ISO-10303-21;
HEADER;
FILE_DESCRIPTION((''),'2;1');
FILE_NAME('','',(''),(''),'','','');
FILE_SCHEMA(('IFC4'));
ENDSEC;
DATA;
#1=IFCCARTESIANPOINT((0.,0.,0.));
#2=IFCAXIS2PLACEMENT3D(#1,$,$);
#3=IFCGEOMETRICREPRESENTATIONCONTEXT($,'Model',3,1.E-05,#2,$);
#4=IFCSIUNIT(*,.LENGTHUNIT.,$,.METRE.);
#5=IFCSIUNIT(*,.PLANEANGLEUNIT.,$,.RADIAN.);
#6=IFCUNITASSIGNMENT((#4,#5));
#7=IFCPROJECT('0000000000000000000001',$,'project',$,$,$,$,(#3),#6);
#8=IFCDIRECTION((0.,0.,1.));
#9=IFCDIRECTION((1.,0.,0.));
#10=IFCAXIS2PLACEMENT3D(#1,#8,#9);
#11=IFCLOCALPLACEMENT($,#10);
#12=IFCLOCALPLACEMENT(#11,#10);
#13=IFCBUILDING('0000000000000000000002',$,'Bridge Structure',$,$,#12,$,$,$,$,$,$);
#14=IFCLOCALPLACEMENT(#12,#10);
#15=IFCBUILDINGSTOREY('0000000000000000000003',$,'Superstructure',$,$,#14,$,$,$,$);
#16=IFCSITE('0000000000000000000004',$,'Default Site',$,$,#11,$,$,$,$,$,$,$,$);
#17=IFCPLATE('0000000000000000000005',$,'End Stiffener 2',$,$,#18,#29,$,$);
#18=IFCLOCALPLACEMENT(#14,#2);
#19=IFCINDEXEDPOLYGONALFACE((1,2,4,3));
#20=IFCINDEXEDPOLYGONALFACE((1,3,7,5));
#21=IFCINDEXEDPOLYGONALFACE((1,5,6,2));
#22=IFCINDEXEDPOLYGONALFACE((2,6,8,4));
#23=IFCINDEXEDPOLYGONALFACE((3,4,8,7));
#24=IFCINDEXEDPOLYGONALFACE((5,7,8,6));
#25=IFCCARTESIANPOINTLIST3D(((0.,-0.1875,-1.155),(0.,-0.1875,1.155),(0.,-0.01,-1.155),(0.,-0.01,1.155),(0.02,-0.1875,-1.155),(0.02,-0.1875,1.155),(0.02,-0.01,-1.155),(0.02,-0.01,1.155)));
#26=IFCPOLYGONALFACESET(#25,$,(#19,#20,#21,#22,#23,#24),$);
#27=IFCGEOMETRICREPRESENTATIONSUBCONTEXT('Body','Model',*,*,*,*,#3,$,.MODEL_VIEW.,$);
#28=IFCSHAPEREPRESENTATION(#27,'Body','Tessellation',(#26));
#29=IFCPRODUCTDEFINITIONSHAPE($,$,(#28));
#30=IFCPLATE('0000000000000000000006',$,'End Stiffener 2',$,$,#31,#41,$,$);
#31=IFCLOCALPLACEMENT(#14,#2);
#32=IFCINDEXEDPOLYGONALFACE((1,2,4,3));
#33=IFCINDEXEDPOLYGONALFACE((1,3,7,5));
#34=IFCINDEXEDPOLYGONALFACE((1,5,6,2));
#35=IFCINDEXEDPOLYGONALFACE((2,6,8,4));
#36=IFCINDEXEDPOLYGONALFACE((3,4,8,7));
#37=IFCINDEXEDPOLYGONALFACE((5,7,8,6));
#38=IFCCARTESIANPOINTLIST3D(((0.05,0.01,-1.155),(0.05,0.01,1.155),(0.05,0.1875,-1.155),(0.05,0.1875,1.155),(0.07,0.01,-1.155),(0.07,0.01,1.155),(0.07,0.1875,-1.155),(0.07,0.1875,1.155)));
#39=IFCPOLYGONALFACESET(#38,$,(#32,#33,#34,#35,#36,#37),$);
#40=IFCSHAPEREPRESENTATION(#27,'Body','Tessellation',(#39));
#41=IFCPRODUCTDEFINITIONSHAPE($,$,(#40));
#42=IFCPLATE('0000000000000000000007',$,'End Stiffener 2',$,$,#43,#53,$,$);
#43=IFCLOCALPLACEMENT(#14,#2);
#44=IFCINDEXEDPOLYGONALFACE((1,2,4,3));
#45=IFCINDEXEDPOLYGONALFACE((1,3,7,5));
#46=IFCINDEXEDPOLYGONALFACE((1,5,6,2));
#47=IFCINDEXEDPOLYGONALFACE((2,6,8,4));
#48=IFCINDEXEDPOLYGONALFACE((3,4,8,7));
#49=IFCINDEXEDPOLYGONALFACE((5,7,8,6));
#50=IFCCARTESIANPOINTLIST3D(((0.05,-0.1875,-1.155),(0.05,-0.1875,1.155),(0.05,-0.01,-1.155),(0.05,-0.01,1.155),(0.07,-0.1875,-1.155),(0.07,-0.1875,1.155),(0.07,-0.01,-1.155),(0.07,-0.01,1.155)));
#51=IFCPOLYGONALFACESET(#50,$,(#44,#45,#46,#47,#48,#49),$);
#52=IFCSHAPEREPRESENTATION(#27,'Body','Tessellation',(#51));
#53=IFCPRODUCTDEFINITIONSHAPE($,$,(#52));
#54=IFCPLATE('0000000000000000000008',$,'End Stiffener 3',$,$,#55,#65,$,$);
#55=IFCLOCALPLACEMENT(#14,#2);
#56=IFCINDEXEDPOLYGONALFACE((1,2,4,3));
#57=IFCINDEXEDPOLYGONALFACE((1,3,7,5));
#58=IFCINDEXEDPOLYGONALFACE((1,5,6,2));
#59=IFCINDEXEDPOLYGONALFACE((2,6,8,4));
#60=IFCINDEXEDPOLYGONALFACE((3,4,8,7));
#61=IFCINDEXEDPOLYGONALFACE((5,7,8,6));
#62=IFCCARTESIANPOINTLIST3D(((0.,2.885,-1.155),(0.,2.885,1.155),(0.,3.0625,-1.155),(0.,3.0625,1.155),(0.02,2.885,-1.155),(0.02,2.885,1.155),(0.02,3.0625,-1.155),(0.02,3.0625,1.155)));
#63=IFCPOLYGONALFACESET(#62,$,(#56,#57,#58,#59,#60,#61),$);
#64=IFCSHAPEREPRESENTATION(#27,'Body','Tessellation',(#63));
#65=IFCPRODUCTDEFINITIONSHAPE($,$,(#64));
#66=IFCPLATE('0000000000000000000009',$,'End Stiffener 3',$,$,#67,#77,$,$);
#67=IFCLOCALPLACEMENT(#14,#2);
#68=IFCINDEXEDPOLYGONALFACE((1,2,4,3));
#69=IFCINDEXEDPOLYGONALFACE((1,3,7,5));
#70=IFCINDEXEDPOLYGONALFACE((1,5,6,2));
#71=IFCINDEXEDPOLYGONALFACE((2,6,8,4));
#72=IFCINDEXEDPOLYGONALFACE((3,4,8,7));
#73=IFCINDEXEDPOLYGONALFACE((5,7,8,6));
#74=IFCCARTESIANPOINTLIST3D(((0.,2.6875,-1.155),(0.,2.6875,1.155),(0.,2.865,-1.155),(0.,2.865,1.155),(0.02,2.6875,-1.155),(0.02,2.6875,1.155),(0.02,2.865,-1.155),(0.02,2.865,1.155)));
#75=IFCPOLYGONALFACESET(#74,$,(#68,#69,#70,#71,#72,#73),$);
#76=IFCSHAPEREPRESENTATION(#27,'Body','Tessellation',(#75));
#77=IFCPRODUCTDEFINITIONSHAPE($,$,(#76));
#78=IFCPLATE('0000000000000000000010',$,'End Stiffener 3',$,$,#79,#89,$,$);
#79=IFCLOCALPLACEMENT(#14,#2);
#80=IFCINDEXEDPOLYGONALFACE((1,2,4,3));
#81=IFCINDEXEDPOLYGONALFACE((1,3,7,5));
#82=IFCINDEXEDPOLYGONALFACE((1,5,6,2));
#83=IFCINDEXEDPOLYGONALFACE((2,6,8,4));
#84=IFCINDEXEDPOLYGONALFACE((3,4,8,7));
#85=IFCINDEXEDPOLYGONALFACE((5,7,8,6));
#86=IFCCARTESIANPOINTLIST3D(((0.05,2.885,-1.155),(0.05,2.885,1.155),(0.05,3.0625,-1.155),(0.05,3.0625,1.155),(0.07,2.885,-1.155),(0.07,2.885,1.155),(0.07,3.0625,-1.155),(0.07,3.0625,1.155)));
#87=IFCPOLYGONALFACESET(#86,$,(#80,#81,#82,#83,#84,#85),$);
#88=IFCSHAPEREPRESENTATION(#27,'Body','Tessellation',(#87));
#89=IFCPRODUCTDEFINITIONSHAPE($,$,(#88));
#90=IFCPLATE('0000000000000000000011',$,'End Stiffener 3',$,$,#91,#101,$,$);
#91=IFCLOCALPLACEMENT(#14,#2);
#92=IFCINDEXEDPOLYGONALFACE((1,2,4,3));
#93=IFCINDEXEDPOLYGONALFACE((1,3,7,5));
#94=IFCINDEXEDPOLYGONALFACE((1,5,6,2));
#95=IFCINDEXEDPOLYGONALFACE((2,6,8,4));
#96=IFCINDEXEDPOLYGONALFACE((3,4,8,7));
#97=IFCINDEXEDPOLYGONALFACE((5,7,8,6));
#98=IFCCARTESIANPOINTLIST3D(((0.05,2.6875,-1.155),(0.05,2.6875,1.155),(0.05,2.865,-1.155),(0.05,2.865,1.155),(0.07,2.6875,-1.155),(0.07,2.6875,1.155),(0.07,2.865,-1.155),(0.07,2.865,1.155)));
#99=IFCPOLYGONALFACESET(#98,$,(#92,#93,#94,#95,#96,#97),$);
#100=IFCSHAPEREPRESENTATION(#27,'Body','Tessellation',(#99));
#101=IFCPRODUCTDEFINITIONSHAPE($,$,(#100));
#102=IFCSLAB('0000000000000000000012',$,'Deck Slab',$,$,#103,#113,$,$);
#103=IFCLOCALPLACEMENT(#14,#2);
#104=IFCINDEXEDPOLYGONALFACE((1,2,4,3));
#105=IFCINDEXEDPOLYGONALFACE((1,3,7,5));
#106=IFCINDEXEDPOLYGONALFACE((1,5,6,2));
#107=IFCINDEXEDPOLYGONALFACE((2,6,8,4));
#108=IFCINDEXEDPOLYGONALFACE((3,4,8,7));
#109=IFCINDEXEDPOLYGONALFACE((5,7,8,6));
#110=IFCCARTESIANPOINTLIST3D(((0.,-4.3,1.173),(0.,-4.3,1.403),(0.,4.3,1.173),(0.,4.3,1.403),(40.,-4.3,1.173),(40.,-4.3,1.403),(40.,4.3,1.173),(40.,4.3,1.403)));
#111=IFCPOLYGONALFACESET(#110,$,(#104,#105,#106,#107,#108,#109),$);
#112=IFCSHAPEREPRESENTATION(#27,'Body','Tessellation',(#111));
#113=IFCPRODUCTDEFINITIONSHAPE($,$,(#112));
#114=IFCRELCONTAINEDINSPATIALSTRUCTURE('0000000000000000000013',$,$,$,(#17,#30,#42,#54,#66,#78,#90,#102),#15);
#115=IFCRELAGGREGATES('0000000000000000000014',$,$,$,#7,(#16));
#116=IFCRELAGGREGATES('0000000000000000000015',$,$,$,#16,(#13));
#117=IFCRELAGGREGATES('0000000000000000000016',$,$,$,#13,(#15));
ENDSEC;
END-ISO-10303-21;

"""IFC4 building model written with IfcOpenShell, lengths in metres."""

from ifc_helpers import new_model, si_unit, frame, origin, origin_with_axes, origin_2d_with_axis, place, context, subcontext, project, spatial, polyline, rectangle, outline, extrude, element, save


model = new_model("IFC4")

# Units and contexts
model_context = context("Model", 3, precision=1e-05, world=origin())
body_context = subcontext(model_context, "Body", "Model", "MODEL_VIEW")
ifc_project = project(units=[si_unit("LENGTHUNIT", "METRE"), si_unit("PLANEANGLEUNIT", "RADIAN")], contexts=[model_context])

# Site, building, storey
site_placement = place(None, origin_with_axes())
site = spatial("IfcSite", under=ifc_project, at=site_placement, Name="Default Site")
building_placement = place(site_placement, origin_with_axes())
building = spatial("IfcBuilding", under=site, at=building_placement, Name="Bridge Structure")
storey_placement = place(building_placement, origin_with_axes())
storey = spatial("IfcBuildingStorey", under=building, at=storey_placement, Name="Superstructure")

# Plates
for number, where, z_axis, x_axis, name in (
    (1, (0.01, -0.0988, -1.155), (0.0, 0.0, 1.0), (1.0, 0.0, 0.0), "End Stiffener 2"),
    (2, (0.06, 0.0988, -1.155), (0.0, 0.0, 1.0), (1.0, 0.0, 0.0), "End Stiffener 2"),
    (3, (0.06, -0.0988, -1.155), (0.0, 0.0, 1.0), (1.0, 0.0, 0.0), "End Stiffener 2"),
    (4, (0.01, 2.9737, -1.155), (0.0, 0.0, 1.0), (1.0, 0.0, 0.0), "End Stiffener 3"),
    (5, (0.01, 2.7763, -1.155), (0.0, 0.0, 1.0), (1.0, 0.0, 0.0), "End Stiffener 3"),
    (6, (0.06, 2.9737, -1.155), (0.0, 0.0, 1.0), (1.0, 0.0, 0.0), "End Stiffener 3"),
    (7, (0.06, 2.7763, -1.155), (0.0, 0.0, 1.0), (1.0, 0.0, 0.0), "End Stiffener 3"),
):
    element("IfcPlate", number, at=place(storey_placement, frame(where, z_axis=z_axis, x_axis=x_axis)), inside=storey, Name=name, context=body_context, shape_type="SweptSolid", body=[
        extrude(rectangle(XDim=0.02, YDim=0.1775, at=origin_2d_with_axis()), origin_with_axes(), (0.0, 0.0, 1.0), 2.31),
    ])

# Slab
slab_placement = place(storey_placement, frame((0.0, 0.0, 1.173), z_axis=(0.0, 0.0, 1.0), x_axis=(1.0, 0.0, 0.0)))
element("IfcSlab", 8, at=slab_placement, inside=storey, Name="Deck Slab", context=body_context, shape_type="SweptSolid", body=[
    extrude(outline(polyline([(0.0, -4.3), (40.0, -4.3), (40.0, 4.3), (0.0, 4.3), (0.0, -4.3)])), origin_with_axes(), (0.0, 0.0, 1.0), 0.23),
])

save(model, "model.ifc")
